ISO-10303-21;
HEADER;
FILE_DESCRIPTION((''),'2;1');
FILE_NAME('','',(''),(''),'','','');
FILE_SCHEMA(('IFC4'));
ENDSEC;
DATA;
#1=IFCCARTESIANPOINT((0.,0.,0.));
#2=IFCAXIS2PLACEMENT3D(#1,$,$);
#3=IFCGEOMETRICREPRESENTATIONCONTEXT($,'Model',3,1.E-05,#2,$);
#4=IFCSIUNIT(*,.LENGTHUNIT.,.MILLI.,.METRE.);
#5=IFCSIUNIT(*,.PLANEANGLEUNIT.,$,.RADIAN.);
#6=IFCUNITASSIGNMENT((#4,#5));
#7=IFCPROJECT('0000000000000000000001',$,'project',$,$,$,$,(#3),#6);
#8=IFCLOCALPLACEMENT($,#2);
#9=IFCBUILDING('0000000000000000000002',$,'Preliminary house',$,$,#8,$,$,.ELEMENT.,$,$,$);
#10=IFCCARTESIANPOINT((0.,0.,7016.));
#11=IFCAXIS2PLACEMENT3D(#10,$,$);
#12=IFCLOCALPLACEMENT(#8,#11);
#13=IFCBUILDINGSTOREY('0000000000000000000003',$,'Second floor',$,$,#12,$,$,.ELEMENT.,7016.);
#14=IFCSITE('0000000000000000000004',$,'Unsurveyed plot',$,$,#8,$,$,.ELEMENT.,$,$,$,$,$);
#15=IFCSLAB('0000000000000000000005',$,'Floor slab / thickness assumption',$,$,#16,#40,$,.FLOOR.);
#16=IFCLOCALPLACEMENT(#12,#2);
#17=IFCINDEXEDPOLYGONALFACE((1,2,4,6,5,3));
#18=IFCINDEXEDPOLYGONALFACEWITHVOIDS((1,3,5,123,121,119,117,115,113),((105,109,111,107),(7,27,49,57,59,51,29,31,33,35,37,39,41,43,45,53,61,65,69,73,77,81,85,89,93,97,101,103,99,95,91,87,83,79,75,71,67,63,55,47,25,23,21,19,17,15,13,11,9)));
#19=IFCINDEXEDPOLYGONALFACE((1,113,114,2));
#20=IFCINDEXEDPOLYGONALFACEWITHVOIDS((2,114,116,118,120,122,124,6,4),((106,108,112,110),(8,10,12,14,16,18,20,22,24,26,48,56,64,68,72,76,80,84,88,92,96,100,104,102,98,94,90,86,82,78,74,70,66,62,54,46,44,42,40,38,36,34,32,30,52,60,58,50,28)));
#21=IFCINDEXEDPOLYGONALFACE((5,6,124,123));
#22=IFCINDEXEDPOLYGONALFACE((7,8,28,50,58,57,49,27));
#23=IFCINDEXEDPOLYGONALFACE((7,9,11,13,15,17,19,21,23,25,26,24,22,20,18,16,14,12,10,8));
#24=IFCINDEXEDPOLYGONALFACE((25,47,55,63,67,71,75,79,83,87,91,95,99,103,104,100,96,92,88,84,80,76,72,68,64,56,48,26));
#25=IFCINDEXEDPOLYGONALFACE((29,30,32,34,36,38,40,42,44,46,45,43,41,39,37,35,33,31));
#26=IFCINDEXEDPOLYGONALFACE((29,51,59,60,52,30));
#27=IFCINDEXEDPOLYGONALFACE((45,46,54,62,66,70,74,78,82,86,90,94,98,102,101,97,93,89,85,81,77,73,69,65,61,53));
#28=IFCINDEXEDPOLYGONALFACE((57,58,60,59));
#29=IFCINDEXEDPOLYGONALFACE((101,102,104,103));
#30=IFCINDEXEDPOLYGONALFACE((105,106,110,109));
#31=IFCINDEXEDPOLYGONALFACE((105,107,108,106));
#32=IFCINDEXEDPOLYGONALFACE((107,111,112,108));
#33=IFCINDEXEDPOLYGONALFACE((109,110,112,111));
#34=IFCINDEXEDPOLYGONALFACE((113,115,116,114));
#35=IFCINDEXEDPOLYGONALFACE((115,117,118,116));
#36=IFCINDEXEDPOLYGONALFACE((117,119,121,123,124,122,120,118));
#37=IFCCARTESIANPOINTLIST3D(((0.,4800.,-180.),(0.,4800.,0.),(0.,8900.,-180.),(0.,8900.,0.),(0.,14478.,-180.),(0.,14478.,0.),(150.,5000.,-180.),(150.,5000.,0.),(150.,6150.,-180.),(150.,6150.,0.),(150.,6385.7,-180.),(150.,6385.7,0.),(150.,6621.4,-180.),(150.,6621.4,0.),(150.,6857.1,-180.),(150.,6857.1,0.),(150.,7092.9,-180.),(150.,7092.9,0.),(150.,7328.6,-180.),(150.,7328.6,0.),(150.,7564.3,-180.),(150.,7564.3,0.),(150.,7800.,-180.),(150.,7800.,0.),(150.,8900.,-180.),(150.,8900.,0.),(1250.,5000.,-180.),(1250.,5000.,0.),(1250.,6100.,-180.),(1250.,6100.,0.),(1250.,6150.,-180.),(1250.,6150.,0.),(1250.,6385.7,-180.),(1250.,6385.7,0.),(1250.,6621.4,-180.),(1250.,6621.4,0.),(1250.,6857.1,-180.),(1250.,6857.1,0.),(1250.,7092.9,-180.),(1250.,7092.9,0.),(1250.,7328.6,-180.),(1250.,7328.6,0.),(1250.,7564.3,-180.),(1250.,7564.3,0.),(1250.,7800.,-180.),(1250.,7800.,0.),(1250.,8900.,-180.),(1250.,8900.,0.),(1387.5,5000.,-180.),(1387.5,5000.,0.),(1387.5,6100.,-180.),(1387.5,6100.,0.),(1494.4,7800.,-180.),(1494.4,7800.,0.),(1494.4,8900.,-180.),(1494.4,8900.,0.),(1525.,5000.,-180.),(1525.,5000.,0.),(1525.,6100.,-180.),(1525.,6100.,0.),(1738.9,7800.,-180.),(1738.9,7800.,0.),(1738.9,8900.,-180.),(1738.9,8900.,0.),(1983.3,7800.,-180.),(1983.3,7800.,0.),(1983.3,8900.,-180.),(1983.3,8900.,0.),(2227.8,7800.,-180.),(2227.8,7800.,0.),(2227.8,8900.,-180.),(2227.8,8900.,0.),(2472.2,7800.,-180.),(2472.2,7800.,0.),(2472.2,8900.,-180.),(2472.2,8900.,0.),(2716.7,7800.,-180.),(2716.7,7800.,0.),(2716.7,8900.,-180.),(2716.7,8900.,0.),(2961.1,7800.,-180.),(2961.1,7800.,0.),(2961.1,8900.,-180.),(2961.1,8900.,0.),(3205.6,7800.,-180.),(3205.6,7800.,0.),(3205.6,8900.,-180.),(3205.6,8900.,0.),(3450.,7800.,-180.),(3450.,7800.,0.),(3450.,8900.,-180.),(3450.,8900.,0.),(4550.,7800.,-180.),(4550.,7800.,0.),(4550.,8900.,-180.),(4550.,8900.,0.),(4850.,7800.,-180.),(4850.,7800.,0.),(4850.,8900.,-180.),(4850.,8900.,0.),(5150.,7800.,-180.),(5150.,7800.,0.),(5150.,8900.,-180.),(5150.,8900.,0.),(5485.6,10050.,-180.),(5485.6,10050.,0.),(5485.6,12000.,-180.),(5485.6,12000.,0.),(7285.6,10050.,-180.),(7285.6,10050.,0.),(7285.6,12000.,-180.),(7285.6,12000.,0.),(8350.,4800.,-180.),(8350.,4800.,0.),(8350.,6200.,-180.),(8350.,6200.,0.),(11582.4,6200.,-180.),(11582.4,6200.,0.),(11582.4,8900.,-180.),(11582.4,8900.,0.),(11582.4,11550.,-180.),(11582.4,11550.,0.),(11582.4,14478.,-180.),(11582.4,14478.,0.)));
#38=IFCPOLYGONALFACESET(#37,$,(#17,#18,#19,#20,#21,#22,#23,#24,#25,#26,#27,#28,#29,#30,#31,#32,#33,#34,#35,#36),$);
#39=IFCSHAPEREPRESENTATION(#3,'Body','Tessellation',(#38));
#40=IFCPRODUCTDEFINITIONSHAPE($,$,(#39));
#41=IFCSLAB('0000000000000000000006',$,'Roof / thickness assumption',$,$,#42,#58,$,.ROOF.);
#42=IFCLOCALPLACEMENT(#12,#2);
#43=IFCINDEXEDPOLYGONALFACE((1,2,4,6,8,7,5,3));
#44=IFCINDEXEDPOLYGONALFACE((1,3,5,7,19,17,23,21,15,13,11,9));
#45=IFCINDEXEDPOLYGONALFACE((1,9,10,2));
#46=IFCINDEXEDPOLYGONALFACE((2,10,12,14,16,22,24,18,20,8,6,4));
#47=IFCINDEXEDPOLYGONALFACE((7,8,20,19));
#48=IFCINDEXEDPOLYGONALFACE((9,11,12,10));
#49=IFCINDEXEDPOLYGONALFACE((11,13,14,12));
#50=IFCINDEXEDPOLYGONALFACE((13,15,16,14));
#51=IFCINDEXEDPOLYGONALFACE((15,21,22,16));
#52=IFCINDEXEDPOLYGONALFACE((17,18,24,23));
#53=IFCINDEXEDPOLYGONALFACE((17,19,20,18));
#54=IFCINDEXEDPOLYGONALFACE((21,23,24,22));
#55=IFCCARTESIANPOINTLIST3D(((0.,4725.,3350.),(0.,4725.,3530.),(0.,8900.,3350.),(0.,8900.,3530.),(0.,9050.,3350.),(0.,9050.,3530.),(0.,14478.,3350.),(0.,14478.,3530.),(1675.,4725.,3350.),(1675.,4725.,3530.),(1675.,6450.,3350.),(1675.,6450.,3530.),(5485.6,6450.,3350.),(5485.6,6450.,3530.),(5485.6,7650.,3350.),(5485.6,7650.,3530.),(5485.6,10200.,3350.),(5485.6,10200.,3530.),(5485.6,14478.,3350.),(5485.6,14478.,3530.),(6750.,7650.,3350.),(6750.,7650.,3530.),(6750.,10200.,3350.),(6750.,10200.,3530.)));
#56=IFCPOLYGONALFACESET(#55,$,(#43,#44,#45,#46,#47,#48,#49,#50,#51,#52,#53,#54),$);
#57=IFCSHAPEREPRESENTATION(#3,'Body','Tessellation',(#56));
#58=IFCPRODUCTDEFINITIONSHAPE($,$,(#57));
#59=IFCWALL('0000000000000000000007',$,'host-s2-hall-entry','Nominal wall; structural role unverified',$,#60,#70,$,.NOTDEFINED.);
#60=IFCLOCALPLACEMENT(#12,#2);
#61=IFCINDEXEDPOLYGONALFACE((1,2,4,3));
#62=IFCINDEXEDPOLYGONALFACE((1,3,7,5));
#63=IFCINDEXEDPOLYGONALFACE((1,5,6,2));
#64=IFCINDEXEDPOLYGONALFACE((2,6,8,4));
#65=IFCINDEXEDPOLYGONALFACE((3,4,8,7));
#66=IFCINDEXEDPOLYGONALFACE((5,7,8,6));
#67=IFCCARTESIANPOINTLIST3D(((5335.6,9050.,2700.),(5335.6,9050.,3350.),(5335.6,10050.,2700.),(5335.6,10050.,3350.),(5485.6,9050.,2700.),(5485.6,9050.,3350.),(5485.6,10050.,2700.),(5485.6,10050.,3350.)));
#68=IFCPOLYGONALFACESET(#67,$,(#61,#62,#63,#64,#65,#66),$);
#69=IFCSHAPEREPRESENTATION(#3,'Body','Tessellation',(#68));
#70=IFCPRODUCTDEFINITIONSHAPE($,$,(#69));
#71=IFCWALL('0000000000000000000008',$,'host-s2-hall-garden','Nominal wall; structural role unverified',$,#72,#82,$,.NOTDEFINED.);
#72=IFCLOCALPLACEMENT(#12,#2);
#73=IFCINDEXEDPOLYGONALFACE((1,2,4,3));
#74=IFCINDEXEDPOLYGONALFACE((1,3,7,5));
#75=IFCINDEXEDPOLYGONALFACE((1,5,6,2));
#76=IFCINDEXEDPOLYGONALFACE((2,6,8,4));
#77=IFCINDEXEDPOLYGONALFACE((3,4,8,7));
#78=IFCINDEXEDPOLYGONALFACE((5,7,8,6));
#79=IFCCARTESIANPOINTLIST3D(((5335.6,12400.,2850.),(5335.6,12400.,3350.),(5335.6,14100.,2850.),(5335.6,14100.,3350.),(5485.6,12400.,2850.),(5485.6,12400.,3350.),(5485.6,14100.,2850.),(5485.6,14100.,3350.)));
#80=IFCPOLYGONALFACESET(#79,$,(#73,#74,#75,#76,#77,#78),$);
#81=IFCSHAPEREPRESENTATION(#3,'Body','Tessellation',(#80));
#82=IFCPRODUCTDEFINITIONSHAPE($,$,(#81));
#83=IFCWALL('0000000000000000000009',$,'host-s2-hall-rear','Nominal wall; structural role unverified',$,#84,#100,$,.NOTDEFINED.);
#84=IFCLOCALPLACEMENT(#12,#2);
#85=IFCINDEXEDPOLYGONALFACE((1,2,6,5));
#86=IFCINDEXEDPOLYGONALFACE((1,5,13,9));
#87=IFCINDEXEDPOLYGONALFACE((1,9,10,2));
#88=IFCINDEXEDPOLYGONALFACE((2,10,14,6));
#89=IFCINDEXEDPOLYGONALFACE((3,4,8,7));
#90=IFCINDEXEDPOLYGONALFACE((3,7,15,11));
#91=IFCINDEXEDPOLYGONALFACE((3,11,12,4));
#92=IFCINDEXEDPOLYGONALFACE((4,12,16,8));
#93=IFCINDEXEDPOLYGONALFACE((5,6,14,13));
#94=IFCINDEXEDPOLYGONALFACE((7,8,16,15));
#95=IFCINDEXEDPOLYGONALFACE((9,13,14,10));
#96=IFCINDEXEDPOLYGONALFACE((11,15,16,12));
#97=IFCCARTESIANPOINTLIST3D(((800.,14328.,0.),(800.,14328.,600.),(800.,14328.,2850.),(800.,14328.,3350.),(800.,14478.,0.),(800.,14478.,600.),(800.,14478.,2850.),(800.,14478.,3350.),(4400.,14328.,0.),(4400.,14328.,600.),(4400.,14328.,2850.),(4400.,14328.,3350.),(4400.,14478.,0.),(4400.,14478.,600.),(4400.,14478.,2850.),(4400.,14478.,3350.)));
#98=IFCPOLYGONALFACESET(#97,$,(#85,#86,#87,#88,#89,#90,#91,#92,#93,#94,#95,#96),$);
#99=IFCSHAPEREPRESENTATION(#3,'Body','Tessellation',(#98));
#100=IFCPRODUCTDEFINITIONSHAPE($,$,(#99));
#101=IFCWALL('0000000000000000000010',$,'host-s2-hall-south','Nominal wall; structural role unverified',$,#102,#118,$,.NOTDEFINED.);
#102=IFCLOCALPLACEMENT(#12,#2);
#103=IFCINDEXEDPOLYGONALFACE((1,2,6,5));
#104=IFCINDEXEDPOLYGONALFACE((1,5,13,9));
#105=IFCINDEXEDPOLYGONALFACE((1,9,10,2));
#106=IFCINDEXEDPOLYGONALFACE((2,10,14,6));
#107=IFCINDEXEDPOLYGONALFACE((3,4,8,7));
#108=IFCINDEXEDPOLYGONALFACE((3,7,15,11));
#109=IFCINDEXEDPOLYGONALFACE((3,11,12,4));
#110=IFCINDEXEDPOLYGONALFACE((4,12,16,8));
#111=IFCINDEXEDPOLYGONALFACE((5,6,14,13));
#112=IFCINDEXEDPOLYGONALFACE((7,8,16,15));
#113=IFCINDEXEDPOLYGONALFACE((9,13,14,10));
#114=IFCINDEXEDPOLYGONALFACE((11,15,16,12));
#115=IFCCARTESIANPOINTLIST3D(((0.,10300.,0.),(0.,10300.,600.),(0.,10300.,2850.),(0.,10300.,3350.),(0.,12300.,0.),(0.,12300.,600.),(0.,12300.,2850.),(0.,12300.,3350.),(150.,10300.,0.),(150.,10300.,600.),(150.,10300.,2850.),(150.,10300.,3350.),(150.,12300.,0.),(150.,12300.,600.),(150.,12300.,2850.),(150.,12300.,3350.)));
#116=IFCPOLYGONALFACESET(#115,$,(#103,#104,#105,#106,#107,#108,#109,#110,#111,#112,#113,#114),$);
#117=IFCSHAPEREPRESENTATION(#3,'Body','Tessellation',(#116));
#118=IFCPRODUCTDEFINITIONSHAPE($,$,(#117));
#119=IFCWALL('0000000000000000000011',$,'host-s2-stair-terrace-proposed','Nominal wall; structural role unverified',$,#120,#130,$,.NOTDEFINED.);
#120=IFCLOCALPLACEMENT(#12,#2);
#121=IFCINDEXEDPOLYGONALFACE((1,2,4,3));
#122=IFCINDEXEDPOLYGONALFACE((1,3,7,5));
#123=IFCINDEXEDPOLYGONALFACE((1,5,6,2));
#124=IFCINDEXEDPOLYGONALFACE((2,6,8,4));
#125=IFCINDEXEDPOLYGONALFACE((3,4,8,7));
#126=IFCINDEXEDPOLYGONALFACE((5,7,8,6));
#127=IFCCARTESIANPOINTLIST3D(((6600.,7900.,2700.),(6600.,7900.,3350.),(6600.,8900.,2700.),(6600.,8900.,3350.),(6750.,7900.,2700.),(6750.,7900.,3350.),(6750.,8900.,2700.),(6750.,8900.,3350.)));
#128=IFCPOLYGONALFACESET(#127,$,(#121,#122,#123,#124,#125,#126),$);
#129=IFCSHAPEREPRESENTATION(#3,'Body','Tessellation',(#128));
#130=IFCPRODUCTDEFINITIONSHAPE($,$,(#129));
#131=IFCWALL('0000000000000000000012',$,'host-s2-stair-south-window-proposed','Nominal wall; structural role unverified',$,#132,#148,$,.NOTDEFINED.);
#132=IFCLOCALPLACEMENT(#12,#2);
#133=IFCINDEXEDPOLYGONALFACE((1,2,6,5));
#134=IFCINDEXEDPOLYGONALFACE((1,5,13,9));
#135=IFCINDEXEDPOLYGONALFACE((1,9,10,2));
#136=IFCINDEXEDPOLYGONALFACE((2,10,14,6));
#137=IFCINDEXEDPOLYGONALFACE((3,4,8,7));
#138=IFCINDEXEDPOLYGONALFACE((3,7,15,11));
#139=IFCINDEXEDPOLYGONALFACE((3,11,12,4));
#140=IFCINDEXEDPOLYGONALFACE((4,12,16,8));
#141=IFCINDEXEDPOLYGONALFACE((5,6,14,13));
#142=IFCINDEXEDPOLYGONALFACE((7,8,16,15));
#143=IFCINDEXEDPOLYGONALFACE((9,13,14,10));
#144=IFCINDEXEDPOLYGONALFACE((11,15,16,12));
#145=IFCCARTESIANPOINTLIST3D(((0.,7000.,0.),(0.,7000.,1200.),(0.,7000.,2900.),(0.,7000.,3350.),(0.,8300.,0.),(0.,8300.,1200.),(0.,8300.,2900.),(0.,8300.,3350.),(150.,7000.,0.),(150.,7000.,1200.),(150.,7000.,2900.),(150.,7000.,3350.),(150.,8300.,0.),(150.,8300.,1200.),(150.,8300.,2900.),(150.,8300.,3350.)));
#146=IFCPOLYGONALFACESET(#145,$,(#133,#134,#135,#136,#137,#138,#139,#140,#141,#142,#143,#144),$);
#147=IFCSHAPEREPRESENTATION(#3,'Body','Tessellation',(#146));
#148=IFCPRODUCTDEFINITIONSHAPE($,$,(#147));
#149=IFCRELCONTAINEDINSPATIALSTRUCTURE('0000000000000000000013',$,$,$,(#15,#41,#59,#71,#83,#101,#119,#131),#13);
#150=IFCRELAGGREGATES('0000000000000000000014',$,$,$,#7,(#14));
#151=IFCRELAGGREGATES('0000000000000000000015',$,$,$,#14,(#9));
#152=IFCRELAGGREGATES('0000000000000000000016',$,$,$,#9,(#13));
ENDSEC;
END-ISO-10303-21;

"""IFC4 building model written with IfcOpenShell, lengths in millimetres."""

from ifc_helpers import new_model, si_unit, frame, origin, place, context, project, spatial, polyline, outline, extrude, element, save


model = new_model("IFC4")

# Units and contexts
model_context = context("Model", 3, precision=1e-05, world=origin())
ifc_project = project(units=[si_unit("LENGTHUNIT", "METRE", prefix="MILLI"), si_unit("PLANEANGLEUNIT", "RADIAN")], contexts=[model_context])

# Site, building, storey
placement_1 = place(None, origin())
site = spatial("IfcSite", under=ifc_project, at=placement_1, Name="Unsurveyed plot", CompositionType="ELEMENT")
building = spatial("IfcBuilding", under=site, at=placement_1, Name="Preliminary house", CompositionType="ELEMENT")
placement_2 = place(placement_1, frame((0.0, 0.0, 7016.0)))
storey = spatial("IfcBuildingStorey", under=building, at=placement_2, Name="Second floor", CompositionType="ELEMENT", Elevation=7016.0)

# Slabs
element("IfcSlab", 1, at=placement_2, inside=storey, Name="Floor slab / thickness assumption", PredefinedType="FLOOR", context=model_context, shape_type="SweptSolid", body=[
    extrude(outline(polyline([(11582.4, 14478.0), (11582.4, 11550.0), (11582.4, 8900.0), (11582.4, 6200.0), (8350.0, 6200.0), (8350.0, 4800.0), (0.0, 4800.0), (0.0, 8900.0), (0.0, 14478.0), (11582.4, 14478.0)]), holes=[polyline([(7285.6, 10050.0), (7285.6, 12000.0), (5485.6, 12000.0), (5485.6, 10050.0), (7285.6, 10050.0)]), polyline([(1387.5, 6100.0), (1250.0, 6100.0), (1250.0, 6150.0), (1250.0, 6385.7), (1250.0, 6621.4), (1250.0, 6857.1), (1250.0, 7092.9), (1250.0, 7328.6), (1250.0, 7564.3), (1250.0, 7800.0), (1494.4, 7800.0), (1738.9, 7800.0), (1983.3, 7800.0), (2227.8, 7800.0), (2472.2, 7800.0), (2716.7, 7800.0), (2961.1, 7800.0), (3205.6, 7800.0), (3450.0, 7800.0), (4550.0, 7800.0), (4850.0, 7800.0), (5150.0, 7800.0), (5150.0, 8900.0), (4850.0, 8900.0), (4550.0, 8900.0), (3450.0, 8900.0), (3205.6, 8900.0), (2961.1, 8900.0), (2716.7, 8900.0), (2472.2, 8900.0), (2227.8, 8900.0), (1983.3, 8900.0), (1738.9, 8900.0), (1494.4, 8900.0), (1250.0, 8900.0), (150.0, 8900.0), (150.0, 7800.0), (150.0, 7564.3), (150.0, 7328.6), (150.0, 7092.9), (150.0, 6857.1), (150.0, 6621.4), (150.0, 6385.7), (150.0, 6150.0), (150.0, 5000.0), (1250.0, 5000.0), (1387.5, 5000.0), (1525.0, 5000.0), (1525.0, 6100.0), (1387.5, 6100.0)])]), frame((0.0, 0.0, -180.0)), (0.0, 0.0, 1.0), 180.0),
])
element("IfcSlab", 2, at=placement_2, inside=storey, Name="Roof / thickness assumption", PredefinedType="ROOF", context=model_context, shape_type="SweptSolid", body=[
    extrude(outline(polyline([(0.0, 9050.0), (0.0, 14478.0), (5485.6, 14478.0), (5485.6, 10200.0), (6750.0, 10200.0), (6750.0, 7650.0), (5485.6, 7650.0), (5485.6, 6450.0), (1675.0, 6450.0), (1675.0, 4725.0), (0.0, 4725.0), (0.0, 8900.0), (0.0, 9050.0)])), frame((0.0, 0.0, 3350.0)), (0.0, 0.0, 1.0), 180.0),
])

# Walls, openings
wall_1 = element("IfcWall", 3, at=placement_2, inside=storey, Name="host-s2-hall-entry", Description="Nominal wall; structural role unverified", PredefinedType="NOTDEFINED", context=model_context, shape_type="SweptSolid", body=[
    extrude(outline(polyline([(5335.6, 10050.0), (5485.6, 10050.0), (5485.6, 9050.0), (5335.6, 9050.0), (5335.6, 10050.0)])), origin(), (0.0, 0.0, 1.0), 3350.0),
])
element("IfcOpeningElement", 4, at=placement_2, cuts=wall_1, PredefinedType="OPENING", context=model_context, shape_type="SweptSolid", body=[
    extrude(outline(polyline([(5860.6, 9050.0), (5860.6, 10050.0), (4960.6, 10050.0), (4960.6, 9050.0), (5860.6, 9050.0)])), origin(), (0.0, 0.0, 1.0), 2700.0),
])
wall_2 = element("IfcWall", 5, at=placement_2, inside=storey, Name="host-s2-hall-garden", Description="Nominal wall; structural role unverified", PredefinedType="NOTDEFINED", context=model_context, shape_type="SweptSolid", body=[
    extrude(outline(polyline([(5335.6, 14100.0), (5485.6, 14100.0), (5485.6, 12400.0), (5335.6, 12400.0), (5335.6, 14100.0)])), origin(), (0.0, 0.0, 1.0), 3350.0),
])
element("IfcOpeningElement", 6, at=placement_2, cuts=wall_2, PredefinedType="OPENING", context=model_context, shape_type="SweptSolid", body=[
    extrude(outline(polyline([(5860.6, 12400.0), (5860.6, 14100.0), (4960.6, 14100.0), (4960.6, 12400.0), (5860.6, 12400.0)])), origin(), (0.0, 0.0, 1.0), 2850.0),
])
wall_3 = element("IfcWall", 7, at=placement_2, inside=storey, Name="host-s2-hall-rear", Description="Nominal wall; structural role unverified", PredefinedType="NOTDEFINED", context=model_context, shape_type="SweptSolid", body=[
    extrude(outline(polyline([(4400.0, 14478.0), (4400.0, 14328.0), (800.0, 14328.0), (800.0, 14478.0), (4400.0, 14478.0)])), origin(), (0.0, 0.0, 1.0), 3350.0),
])
element("IfcOpeningElement", 8, at=placement_2, cuts=wall_3, PredefinedType="OPENING", context=model_context, shape_type="SweptSolid", body=[
    extrude(outline(polyline([(800.0, 13953.0), (4400.0, 13953.0), (4400.0, 14853.0), (800.0, 14853.0), (800.0, 13953.0)])), frame((0.0, 0.0, 600.0)), (0.0, 0.0, 1.0), 2250.0),
])
wall_4 = element("IfcWall", 9, at=placement_2, inside=storey, Name="host-s2-hall-south", Description="Nominal wall; structural role unverified", PredefinedType="NOTDEFINED", context=model_context, shape_type="SweptSolid", body=[
    extrude(outline(polyline([(0.0, 12300.0), (150.0, 12300.0), (150.0, 10300.0), (0.0, 10300.0), (0.0, 12300.0)])), origin(), (0.0, 0.0, 1.0), 3350.0),
])
element("IfcOpeningElement", 10, at=placement_2, cuts=wall_4, PredefinedType="OPENING", context=model_context, shape_type="SweptSolid", body=[
    extrude(outline(polyline([(525.0, 10300.0), (525.0, 12300.0), (-375.0, 12300.0), (-375.0, 10300.0), (525.0, 10300.0)])), frame((0.0, 0.0, 600.0)), (0.0, 0.0, 1.0), 2250.0),
])
wall_5 = element("IfcWall", 11, at=placement_2, inside=storey, Name="host-s2-stair-terrace-proposed", Description="Nominal wall; structural role unverified", PredefinedType="NOTDEFINED", context=model_context, shape_type="SweptSolid", body=[
    extrude(outline(polyline([(6600.0, 8900.0), (6750.0, 8900.0), (6750.0, 7900.0), (6600.0, 7900.0), (6600.0, 8900.0)])), origin(), (0.0, 0.0, 1.0), 3350.0),
])
element("IfcOpeningElement", 12, at=placement_2, cuts=wall_5, PredefinedType="OPENING", context=model_context, shape_type="SweptSolid", body=[
    extrude(outline(polyline([(7125.0, 7900.0), (7125.0, 8900.0), (6225.0, 8900.0), (6225.0, 7900.0), (7125.0, 7900.0)])), origin(), (0.0, 0.0, 1.0), 2700.0),
])
wall_6 = element("IfcWall", 13, at=placement_2, inside=storey, Name="host-s2-stair-south-window-proposed", Description="Nominal wall; structural role unverified", PredefinedType="NOTDEFINED", context=model_context, shape_type="SweptSolid", body=[
    extrude(outline(polyline([(0.0, 8300.0), (150.0, 8300.0), (150.0, 7000.0), (0.0, 7000.0), (0.0, 8300.0)])), origin(), (0.0, 0.0, 1.0), 3350.0),
])
element("IfcOpeningElement", 14, at=placement_2, cuts=wall_6, PredefinedType="OPENING", context=model_context, shape_type="SweptSolid", body=[
    extrude(outline(polyline([(525.0, 7000.0), (525.0, 8300.0), (-375.0, 8300.0), (-375.0, 7000.0), (525.0, 7000.0)])), frame((0.0, 0.0, 1200.0)), (0.0, 0.0, 1.0), 1700.0),
])

save(model, "model.ifc")
